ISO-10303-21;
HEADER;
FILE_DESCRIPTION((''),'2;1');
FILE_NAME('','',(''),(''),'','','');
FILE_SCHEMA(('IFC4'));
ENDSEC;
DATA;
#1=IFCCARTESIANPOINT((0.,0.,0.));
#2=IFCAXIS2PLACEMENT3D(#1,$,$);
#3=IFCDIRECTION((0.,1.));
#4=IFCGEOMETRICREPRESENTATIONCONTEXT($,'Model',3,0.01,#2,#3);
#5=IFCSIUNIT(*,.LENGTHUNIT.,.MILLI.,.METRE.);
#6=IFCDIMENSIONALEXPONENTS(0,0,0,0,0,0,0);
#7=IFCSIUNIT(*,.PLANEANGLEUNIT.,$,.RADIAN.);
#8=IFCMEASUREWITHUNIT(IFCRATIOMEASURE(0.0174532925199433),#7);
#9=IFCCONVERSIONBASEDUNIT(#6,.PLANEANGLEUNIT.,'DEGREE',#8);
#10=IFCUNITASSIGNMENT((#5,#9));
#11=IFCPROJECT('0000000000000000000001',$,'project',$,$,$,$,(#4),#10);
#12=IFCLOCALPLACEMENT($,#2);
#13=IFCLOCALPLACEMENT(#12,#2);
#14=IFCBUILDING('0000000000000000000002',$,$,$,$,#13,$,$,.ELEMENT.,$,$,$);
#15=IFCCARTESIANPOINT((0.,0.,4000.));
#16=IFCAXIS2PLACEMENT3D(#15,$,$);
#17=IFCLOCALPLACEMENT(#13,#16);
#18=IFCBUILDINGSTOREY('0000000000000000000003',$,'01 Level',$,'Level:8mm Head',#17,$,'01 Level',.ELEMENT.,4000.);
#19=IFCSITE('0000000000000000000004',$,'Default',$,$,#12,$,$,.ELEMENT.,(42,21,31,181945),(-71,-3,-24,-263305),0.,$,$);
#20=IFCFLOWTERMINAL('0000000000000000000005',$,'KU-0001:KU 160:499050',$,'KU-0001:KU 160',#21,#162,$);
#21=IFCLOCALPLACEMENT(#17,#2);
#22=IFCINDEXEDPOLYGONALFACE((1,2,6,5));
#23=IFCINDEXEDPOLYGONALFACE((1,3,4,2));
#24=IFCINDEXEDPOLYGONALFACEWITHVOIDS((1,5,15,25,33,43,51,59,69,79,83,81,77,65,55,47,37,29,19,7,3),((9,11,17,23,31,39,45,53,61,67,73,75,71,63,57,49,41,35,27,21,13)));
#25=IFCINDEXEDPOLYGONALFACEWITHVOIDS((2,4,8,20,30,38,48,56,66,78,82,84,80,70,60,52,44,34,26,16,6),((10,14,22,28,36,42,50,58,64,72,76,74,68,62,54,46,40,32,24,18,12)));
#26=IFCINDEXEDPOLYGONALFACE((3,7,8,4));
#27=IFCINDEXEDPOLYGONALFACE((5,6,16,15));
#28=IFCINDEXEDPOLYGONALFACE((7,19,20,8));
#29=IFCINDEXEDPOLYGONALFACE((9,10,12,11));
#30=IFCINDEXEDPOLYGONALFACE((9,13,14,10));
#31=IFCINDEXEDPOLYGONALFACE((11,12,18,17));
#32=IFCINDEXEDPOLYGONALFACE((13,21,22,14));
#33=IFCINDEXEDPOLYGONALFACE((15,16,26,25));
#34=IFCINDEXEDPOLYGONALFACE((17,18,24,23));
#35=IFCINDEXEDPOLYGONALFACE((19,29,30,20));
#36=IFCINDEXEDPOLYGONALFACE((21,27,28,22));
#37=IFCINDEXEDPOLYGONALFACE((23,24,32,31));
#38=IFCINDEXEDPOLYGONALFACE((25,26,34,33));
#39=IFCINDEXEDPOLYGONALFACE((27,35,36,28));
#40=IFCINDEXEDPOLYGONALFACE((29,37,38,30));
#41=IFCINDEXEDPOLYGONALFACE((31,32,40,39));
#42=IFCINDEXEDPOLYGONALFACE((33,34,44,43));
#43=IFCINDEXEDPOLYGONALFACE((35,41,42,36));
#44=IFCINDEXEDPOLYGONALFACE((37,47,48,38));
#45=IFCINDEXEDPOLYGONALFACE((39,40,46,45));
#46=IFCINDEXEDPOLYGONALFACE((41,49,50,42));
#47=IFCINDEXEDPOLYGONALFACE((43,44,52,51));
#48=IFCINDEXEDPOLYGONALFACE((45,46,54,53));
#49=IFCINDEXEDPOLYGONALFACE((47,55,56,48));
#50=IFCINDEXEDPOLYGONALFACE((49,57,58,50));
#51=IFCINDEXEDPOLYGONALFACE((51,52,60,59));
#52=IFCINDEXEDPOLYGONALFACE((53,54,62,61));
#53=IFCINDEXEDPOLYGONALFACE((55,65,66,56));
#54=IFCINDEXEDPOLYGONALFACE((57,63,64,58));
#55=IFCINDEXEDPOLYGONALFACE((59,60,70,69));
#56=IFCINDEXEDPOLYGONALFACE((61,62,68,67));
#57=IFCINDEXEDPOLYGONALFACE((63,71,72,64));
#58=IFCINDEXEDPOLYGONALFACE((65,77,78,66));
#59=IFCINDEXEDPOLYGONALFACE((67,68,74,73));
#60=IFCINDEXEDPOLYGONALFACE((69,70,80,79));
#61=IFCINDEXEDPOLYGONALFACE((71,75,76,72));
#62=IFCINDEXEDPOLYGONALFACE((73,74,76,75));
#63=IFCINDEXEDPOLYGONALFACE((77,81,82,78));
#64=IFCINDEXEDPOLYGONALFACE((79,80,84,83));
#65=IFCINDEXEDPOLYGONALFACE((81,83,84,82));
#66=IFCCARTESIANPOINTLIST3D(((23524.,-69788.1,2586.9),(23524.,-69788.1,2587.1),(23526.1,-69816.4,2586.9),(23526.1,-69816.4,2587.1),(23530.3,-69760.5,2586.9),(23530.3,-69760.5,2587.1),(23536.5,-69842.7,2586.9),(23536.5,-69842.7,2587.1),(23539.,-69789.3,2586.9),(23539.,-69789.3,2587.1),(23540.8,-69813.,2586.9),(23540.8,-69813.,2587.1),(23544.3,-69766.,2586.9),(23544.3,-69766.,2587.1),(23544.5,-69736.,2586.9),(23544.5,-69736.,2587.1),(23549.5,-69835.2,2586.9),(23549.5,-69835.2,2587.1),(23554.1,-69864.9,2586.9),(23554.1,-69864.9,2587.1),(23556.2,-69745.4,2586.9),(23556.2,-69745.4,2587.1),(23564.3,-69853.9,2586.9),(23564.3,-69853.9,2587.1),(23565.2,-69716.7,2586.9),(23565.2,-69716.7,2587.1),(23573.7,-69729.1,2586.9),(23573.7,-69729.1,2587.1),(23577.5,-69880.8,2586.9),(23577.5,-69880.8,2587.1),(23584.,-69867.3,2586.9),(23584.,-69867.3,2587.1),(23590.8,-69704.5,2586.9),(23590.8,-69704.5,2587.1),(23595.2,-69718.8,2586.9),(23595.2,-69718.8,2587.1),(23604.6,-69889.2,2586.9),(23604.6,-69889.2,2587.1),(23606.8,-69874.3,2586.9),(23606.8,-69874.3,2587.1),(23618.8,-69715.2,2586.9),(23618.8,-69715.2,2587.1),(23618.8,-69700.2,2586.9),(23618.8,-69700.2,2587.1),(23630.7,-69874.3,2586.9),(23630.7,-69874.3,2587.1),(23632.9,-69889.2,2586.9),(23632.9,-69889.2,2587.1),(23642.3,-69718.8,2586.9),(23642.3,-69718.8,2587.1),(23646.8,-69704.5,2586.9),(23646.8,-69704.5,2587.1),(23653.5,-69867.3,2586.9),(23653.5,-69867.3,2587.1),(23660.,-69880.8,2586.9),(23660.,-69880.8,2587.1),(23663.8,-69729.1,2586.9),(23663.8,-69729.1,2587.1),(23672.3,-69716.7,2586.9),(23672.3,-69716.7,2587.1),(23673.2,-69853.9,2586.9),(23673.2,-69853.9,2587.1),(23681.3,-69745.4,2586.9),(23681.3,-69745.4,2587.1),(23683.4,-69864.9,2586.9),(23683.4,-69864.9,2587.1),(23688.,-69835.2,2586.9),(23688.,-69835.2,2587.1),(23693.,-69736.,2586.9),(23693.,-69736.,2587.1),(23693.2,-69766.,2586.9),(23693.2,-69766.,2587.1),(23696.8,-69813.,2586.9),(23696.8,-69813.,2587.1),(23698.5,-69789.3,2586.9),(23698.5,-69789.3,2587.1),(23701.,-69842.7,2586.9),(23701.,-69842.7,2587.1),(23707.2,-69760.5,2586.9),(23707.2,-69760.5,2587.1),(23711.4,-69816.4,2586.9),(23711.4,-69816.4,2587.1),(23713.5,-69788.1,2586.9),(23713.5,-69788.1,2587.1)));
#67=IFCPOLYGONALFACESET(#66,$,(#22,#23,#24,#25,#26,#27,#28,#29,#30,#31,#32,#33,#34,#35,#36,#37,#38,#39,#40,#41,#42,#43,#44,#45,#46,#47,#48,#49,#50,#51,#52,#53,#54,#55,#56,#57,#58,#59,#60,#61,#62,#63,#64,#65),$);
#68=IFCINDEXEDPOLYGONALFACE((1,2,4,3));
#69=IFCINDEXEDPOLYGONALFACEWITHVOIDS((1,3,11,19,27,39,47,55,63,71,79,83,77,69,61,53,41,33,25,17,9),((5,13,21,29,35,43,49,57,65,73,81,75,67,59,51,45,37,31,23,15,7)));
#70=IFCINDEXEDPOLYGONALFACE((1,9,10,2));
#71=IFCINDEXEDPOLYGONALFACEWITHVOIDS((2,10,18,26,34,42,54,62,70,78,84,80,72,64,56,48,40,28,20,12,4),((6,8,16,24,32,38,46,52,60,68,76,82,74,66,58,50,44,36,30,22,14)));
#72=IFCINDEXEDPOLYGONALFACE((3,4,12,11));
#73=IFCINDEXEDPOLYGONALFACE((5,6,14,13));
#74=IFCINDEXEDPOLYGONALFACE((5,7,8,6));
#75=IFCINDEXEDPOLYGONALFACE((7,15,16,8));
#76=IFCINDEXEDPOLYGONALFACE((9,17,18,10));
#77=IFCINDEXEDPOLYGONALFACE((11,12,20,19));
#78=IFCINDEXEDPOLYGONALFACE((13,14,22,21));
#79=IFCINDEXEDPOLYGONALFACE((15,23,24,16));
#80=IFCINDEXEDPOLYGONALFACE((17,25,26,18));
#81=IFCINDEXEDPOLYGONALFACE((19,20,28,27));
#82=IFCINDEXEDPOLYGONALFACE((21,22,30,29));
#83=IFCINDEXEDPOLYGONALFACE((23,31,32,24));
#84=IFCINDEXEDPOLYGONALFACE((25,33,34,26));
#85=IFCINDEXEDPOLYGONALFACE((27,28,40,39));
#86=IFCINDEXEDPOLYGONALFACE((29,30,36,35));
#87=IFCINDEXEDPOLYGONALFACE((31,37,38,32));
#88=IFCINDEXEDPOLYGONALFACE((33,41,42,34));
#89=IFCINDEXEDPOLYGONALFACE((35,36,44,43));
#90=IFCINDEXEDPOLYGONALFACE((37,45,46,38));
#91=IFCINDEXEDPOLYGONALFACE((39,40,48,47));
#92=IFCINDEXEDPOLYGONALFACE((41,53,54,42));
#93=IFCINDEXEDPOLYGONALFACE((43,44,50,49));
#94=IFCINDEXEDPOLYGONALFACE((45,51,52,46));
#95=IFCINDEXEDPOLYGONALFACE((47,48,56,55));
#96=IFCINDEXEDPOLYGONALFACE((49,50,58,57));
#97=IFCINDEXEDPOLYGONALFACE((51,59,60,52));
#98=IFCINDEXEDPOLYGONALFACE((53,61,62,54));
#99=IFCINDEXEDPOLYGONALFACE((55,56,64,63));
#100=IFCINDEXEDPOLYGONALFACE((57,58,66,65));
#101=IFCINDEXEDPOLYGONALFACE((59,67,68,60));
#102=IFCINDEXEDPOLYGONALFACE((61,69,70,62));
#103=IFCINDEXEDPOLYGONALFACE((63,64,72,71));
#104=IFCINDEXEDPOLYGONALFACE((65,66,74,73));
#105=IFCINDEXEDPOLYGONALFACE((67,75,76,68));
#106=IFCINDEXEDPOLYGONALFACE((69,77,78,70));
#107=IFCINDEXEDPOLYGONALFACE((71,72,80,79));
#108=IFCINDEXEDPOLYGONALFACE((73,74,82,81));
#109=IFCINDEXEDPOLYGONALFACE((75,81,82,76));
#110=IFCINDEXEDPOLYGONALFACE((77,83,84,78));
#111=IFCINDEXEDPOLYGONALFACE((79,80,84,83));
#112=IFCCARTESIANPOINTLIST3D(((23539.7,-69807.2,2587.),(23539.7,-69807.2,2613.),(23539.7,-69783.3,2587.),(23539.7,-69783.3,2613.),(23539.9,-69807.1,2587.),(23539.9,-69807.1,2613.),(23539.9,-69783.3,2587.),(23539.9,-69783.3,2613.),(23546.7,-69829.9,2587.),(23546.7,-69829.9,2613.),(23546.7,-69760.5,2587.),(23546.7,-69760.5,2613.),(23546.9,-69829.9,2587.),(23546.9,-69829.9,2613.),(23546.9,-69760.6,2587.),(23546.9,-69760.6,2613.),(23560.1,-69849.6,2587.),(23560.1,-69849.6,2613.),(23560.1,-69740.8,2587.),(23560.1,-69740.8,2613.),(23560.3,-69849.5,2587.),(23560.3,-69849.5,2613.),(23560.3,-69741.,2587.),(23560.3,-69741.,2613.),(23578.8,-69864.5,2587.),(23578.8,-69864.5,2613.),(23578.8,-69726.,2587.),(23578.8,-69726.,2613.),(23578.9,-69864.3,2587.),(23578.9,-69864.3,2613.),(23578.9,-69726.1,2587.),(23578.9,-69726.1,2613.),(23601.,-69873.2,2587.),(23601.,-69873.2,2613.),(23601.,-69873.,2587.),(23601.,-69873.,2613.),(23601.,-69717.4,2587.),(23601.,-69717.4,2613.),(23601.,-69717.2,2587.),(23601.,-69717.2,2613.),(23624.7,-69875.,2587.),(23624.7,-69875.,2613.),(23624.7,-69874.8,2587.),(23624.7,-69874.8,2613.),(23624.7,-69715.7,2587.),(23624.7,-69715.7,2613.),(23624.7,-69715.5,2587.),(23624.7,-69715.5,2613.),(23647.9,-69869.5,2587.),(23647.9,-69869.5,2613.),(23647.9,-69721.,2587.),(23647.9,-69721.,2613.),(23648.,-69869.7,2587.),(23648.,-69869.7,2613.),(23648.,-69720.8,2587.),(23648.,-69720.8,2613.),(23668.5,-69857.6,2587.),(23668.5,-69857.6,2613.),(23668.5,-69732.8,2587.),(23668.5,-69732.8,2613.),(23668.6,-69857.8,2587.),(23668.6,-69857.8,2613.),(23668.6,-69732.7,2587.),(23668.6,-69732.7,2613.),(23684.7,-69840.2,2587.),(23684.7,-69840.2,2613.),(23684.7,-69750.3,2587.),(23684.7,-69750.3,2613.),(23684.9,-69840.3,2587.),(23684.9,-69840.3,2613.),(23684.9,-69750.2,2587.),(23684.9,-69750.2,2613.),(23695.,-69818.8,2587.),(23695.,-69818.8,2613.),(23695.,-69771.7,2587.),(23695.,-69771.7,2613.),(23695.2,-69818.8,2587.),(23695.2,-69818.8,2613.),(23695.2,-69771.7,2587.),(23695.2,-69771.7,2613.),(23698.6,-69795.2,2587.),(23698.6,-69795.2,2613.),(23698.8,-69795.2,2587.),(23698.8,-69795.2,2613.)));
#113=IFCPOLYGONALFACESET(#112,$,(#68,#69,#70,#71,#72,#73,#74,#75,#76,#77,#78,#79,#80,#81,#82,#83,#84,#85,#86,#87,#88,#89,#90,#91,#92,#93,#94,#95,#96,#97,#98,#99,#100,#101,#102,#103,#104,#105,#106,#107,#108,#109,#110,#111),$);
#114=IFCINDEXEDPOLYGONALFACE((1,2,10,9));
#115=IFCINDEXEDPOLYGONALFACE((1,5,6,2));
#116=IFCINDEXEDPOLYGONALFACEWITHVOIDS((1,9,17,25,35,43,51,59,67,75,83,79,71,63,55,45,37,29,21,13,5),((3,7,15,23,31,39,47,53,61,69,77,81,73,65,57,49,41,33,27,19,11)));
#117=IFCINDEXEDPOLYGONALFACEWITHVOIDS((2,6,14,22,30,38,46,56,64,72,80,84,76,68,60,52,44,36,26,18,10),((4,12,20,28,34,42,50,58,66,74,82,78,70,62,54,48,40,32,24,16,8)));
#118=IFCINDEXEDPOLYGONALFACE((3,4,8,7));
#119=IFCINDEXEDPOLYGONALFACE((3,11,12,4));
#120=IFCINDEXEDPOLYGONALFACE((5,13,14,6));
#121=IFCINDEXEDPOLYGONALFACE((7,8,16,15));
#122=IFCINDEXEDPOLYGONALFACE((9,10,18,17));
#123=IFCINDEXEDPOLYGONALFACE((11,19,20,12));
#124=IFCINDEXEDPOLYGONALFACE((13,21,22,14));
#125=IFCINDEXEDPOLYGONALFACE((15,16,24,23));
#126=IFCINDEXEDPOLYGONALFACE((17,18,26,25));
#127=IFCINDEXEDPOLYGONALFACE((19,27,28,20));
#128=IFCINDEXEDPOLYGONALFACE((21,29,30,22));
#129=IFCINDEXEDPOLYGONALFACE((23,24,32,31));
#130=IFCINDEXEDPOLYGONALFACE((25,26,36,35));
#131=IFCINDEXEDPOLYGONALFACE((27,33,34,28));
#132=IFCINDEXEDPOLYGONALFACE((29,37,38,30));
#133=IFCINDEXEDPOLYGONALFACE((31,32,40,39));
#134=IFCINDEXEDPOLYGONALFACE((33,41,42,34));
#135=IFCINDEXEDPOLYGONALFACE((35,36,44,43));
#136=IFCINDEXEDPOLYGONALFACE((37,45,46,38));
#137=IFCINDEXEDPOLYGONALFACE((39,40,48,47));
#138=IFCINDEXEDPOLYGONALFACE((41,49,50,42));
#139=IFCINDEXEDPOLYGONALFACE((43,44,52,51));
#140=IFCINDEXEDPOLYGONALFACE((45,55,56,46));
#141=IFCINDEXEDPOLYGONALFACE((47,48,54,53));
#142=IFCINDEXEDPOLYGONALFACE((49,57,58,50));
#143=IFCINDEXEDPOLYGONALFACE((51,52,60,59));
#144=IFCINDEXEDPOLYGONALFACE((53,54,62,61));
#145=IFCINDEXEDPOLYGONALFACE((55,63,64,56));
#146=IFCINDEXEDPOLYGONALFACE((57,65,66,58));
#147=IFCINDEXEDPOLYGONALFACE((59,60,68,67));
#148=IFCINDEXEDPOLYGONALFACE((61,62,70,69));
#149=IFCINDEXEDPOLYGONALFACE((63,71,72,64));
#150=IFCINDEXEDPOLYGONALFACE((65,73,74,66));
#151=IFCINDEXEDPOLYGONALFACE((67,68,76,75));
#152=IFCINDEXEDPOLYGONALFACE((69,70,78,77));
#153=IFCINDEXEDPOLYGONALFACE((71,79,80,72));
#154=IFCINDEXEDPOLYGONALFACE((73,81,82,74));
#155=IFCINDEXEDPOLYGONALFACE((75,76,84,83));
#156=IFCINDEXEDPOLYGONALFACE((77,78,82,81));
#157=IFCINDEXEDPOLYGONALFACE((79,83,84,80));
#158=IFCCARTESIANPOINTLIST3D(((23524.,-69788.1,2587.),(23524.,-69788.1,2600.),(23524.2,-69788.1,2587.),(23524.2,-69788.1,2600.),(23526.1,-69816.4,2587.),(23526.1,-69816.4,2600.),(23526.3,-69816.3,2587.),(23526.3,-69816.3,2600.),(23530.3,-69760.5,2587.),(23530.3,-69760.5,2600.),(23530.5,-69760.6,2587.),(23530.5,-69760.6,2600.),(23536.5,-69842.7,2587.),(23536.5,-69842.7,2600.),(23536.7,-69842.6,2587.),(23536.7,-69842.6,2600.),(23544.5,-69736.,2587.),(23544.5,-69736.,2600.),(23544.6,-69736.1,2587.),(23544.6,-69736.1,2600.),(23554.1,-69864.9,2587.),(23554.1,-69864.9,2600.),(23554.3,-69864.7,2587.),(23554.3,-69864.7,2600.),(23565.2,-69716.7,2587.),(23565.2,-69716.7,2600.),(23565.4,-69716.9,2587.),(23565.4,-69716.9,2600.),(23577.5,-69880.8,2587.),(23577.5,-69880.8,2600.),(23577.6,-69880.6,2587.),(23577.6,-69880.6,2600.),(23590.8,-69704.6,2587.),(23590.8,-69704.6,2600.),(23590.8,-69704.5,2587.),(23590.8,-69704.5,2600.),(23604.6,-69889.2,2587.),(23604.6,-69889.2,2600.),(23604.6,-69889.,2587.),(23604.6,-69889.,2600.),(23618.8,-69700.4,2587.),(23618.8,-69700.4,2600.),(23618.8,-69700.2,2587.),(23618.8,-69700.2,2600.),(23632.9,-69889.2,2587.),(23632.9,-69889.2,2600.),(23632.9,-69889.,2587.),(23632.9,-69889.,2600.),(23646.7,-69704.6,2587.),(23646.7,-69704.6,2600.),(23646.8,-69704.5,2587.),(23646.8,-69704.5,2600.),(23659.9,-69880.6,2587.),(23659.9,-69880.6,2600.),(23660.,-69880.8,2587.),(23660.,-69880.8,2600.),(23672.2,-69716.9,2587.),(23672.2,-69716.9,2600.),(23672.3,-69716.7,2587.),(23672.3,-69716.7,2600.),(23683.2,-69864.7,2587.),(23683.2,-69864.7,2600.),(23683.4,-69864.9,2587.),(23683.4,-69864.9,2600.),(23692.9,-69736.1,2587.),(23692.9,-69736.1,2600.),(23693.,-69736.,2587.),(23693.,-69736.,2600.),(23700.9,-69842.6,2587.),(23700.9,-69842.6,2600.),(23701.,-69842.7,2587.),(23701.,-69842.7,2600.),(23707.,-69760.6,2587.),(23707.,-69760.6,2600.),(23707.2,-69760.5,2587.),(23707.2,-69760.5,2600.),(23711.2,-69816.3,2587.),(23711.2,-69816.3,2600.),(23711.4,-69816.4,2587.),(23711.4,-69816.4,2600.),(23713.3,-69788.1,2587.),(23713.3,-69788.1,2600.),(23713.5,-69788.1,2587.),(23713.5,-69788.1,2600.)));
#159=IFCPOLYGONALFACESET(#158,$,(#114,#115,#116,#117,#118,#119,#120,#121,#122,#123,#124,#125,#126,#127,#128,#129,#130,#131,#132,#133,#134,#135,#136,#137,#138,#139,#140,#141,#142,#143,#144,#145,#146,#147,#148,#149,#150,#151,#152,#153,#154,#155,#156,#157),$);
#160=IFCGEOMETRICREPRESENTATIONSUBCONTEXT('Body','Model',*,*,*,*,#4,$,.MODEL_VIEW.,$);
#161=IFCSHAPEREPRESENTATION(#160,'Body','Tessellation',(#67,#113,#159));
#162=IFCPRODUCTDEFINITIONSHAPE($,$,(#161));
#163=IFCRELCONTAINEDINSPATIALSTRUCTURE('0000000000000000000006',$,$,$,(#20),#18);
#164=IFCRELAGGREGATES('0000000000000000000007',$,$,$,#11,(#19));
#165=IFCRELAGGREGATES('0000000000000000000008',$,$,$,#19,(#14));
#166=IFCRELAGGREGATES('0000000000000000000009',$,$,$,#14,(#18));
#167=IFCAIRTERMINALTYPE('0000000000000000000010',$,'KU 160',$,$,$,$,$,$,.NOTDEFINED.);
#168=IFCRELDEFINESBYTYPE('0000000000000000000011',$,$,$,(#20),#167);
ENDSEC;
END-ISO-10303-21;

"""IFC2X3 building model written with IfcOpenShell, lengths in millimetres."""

from ifc_helpers import new_model, entity, si_unit, converted_unit, direction, frame, frame_2d, origin, place, context, subcontext, project, spatial, hollow_circle, extrude, source, transform, mapped, type_object, type_shapes, element, save


model = new_model("IFC2X3")

# Units and contexts
model_context = context("Model", 3, precision=0.01, world=origin(), true_north=direction((0.0, 1.0)))
body_context = subcontext(model_context, "Body", "Model", "MODEL_VIEW")
ifc_project = project(units=[si_unit("LENGTHUNIT", "METRE", prefix="MILLI"), converted_unit("PLANEANGLEUNIT", "DEGREE", entity("IfcRatioMeasure", 0.0174532925199433), si_unit("PLANEANGLEUNIT", "RADIAN"), dimensions=[0, 0, 0, 0, 0, 0, 0])], contexts=[model_context])

# Site, building, storey
site_placement = place(None, origin())
site = spatial("IfcSite", under=ifc_project, at=site_placement, Name="Default", CompositionType="ELEMENT", RefLatitude=(42, 21, 31, 181945), RefLongitude=(-71, -3, -24, -263305), RefElevation=0.0)
building_placement = place(site_placement, origin())
building = spatial("IfcBuilding", under=site, at=building_placement, CompositionType="ELEMENT")
storey_placement = place(building_placement, frame((0.0, 0.0, 4000.0)))
storey = spatial("IfcBuildingStorey", under=building, at=storey_placement, Name="01 Level", ObjectType="Level:8mm Head", LongName="01 Level", CompositionType="ELEMENT", Elevation=4000.0)

# Flow terminal
air_terminal_type_1 = type_object("IfcAirTerminalType", Name="KU 160", PredefinedType="NOTDEFINED")
shared_shape_1 = source(origin(), body_context, "Body", "SweptSolid", [
    extrude(hollow_circle(Radius=95.0, WallThickness=15.0, at=frame_2d((0.0, 0.0), x_axis=(1.0, 0.0))), frame((12.9, 0.0, 0.0), z_axis=(1.0, 0.0, 0.0), x_axis=(0.0, 1.0, 0.0)), (0.0, 0.0, 1.0), 0.2),
    extrude(hollow_circle(Radius=80.0, WallThickness=0.2, at=frame_2d((0.0, 0.0), x_axis=(1.0, 0.0))), frame((-13.0, 0.0, 0.0), z_axis=(1.0, 0.0, 0.0), x_axis=(0.0, 0.0, 1.0)), (0.0, 0.0, 1.0), 26.0),
    extrude(hollow_circle(Radius=95.0, WallThickness=0.2, at=frame_2d((0.0, 0.0), x_axis=(1.0, 0.0))), frame((0.0, 0.0, 0.0), z_axis=(1.0, 0.0, 0.0), x_axis=(0.0, 1.0, 0.0)), (0.0, 0.0, 1.0), 13.0),
])
type_shapes(air_terminal_type_1, [shared_shape_1])
for number, where, z_axis, x_axis, name in (
    (1, (23618.8, -69795.2, 2600.0), (1.0, 0.0, 0.0), (0.0, 0.0, -1.0), "KU-0001:KU 160:499050"),
):
    element("IfcFlowTerminal", number, at=place(storey_placement, frame(where, z_axis=z_axis, x_axis=x_axis)), inside=storey, type_object=air_terminal_type_1, Name=name, ObjectType="KU-0001:KU 160", context=body_context, shape_type="MappedRepresentation", body=[
        mapped(shared_shape_1, transform((0.0, 0.0, 0.0), scale=1.0)),
    ])

save(model, "model.ifc")
